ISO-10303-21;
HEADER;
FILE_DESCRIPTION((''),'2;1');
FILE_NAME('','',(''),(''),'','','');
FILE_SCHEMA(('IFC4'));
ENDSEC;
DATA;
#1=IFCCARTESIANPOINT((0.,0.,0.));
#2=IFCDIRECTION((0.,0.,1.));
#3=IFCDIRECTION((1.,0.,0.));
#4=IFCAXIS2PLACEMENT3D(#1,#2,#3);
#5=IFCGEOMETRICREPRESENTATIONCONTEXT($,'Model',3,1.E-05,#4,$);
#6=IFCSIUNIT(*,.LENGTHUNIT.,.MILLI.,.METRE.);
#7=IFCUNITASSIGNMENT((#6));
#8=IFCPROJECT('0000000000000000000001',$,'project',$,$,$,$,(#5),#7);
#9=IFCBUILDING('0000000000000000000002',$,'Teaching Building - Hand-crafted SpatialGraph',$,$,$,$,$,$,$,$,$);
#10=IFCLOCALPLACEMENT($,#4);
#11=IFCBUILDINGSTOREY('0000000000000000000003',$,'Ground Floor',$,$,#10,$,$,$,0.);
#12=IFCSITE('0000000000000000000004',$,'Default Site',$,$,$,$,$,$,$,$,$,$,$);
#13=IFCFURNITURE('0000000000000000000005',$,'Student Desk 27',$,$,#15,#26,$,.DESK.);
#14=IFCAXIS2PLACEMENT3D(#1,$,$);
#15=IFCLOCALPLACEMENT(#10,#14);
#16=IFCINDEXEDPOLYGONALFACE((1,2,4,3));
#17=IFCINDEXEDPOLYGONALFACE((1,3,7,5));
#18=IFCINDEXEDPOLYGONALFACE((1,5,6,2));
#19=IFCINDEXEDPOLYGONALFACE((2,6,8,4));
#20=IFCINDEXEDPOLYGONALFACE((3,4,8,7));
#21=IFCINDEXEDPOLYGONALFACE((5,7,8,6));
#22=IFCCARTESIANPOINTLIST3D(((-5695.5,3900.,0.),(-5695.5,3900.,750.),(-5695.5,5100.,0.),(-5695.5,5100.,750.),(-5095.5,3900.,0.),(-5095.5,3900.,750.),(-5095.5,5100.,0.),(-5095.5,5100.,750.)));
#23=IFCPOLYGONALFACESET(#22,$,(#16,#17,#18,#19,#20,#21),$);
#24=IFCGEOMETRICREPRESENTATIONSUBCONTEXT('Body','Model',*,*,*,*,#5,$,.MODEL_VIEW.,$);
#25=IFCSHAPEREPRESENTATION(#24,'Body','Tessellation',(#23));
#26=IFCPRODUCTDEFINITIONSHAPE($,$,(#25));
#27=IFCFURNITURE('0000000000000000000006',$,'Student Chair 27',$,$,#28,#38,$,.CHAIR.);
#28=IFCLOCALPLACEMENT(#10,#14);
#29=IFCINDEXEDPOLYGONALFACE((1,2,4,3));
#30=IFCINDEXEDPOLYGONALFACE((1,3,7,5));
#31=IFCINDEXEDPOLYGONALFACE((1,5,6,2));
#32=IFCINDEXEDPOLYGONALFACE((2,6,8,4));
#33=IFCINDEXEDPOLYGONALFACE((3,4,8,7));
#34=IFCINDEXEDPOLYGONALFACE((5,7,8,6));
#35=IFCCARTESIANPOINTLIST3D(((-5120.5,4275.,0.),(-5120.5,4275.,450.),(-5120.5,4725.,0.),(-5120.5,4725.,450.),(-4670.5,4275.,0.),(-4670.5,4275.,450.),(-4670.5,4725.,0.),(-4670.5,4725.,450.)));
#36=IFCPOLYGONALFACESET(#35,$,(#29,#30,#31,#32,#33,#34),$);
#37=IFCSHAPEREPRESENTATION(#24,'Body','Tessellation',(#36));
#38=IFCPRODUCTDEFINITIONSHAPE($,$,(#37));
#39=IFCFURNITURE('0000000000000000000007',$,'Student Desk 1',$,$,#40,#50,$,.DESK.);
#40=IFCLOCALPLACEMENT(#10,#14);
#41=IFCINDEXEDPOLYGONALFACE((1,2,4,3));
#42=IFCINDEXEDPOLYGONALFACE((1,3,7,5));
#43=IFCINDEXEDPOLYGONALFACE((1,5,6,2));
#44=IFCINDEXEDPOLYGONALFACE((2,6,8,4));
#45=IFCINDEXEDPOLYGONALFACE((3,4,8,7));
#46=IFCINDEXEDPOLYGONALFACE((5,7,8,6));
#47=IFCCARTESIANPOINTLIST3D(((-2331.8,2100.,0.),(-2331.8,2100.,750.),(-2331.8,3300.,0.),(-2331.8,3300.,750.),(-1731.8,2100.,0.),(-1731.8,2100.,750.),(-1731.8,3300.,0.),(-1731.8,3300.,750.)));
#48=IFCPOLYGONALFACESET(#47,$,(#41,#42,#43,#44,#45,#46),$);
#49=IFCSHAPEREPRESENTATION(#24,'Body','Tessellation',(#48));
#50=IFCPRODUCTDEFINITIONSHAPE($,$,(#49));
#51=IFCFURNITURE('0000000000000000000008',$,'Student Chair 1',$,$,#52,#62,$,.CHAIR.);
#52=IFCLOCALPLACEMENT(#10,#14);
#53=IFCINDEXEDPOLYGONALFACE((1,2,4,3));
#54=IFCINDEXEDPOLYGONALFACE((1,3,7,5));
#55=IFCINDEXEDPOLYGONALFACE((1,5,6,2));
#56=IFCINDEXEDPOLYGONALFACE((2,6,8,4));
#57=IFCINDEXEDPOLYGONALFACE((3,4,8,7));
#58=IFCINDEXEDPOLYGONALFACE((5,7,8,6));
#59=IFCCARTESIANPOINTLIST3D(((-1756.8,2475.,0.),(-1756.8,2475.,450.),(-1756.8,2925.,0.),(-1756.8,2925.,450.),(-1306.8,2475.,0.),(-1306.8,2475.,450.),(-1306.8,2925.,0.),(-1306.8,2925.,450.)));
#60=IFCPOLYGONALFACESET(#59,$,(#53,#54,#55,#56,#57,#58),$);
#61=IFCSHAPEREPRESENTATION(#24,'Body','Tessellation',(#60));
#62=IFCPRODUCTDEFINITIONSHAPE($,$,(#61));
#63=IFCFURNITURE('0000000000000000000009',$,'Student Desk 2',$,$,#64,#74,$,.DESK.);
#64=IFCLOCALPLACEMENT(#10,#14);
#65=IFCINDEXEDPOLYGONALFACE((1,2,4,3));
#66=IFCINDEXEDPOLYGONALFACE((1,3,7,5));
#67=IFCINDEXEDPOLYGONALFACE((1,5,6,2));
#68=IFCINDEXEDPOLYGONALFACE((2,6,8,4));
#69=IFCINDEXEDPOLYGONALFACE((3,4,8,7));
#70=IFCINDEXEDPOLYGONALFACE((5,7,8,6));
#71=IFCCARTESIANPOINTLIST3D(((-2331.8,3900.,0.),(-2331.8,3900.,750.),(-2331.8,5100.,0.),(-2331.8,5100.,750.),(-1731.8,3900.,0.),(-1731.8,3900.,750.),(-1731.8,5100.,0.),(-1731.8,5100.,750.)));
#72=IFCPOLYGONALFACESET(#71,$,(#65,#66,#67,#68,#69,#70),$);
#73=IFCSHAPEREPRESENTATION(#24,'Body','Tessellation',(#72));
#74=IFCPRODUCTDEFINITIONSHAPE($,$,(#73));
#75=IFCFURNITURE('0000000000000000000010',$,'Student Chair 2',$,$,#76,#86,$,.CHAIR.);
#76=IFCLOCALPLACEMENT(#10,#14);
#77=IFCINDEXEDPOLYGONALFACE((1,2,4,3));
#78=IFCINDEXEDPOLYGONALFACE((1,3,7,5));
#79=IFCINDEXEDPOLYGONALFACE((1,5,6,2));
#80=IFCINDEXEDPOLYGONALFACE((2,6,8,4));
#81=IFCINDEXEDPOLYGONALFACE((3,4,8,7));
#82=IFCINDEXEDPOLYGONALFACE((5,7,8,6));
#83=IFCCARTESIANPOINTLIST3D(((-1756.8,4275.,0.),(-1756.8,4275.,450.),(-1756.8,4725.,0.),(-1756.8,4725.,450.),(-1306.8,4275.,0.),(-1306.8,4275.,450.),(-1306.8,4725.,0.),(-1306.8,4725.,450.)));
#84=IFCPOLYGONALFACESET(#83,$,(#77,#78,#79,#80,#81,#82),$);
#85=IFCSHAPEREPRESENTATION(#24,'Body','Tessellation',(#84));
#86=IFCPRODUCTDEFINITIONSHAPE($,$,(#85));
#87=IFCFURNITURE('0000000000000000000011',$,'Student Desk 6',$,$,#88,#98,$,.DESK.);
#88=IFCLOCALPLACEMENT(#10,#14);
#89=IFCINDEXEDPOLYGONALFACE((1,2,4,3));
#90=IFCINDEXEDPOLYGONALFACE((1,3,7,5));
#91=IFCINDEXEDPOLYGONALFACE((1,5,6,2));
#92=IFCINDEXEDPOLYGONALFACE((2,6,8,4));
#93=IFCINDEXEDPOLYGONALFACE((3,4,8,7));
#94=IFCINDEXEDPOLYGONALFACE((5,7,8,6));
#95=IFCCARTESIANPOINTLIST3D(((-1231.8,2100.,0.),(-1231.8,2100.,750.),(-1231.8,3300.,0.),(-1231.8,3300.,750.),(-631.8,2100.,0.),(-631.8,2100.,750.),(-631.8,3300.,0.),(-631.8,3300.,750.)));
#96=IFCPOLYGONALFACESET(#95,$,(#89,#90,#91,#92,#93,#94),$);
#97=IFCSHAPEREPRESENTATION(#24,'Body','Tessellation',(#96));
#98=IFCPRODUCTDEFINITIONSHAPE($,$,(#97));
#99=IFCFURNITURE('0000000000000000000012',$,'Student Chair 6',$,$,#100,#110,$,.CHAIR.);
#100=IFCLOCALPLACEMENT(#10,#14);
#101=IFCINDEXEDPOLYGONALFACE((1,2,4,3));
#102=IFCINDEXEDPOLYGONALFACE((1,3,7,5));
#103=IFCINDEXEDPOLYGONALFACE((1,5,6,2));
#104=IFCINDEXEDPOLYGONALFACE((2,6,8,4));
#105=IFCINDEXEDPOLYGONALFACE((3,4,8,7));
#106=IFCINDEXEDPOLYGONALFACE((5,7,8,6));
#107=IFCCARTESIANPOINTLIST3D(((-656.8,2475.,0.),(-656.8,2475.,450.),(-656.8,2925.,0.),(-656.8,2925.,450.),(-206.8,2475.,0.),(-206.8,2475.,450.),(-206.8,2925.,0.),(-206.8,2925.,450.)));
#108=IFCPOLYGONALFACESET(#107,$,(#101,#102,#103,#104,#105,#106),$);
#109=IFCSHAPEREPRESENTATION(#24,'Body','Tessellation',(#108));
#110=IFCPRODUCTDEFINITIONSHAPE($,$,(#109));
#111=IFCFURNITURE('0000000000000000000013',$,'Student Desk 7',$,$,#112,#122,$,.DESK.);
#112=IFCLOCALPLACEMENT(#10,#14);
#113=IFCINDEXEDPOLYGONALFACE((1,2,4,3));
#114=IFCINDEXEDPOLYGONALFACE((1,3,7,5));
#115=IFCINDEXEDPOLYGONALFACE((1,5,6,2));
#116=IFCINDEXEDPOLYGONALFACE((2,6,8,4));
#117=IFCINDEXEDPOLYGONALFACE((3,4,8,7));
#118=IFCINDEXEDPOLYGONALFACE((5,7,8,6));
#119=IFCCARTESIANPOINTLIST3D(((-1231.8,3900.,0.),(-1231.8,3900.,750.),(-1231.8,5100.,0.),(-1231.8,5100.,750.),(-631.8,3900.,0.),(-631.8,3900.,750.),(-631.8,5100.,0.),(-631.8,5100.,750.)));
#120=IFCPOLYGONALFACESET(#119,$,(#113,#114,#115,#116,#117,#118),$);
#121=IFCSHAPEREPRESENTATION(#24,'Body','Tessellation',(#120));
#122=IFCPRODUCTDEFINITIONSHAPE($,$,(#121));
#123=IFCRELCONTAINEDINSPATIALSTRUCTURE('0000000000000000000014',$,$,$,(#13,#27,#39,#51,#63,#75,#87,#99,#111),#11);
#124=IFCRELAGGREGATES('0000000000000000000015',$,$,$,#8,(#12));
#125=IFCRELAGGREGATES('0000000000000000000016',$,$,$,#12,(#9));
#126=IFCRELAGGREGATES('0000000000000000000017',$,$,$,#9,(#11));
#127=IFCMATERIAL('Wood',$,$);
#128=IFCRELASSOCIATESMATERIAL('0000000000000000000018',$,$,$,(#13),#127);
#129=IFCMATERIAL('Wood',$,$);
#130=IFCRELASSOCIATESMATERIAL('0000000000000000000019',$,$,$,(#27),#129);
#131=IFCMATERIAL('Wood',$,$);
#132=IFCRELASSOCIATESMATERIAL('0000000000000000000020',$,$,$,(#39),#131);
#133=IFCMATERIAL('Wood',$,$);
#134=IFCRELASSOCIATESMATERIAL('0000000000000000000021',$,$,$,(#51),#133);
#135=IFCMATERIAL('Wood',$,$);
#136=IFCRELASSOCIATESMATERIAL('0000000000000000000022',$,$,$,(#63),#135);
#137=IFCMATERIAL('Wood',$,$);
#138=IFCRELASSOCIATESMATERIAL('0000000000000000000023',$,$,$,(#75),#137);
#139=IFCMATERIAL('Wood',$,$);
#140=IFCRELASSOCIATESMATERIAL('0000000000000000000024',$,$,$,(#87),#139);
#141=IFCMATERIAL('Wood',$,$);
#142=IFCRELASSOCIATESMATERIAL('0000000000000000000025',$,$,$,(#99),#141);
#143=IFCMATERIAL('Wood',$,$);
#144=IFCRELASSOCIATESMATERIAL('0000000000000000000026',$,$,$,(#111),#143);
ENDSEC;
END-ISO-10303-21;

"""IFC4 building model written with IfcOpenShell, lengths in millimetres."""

from ifc_helpers import new_model, si_unit, frame, origin_with_axes, origin_2d, place, context, subcontext, project, spatial, rectangle, extrude, material, element, save


model = new_model("IFC4")

# Units and contexts
model_context = context("Model", 3, precision=1e-05, world=origin_with_axes())
body_context = subcontext(model_context, "Body", "Model", "MODEL_VIEW")
ifc_project = project(units=[si_unit("LENGTHUNIT", "METRE", prefix="MILLI")], contexts=[model_context])

# Site, building, storey
site = spatial("IfcSite", under=ifc_project, Name="Default Site")
building = spatial("IfcBuilding", under=site, Name="Teaching Building - Hand-crafted SpatialGraph")
storey_placement = place(None, origin_with_axes())
storey = spatial("IfcBuildingStorey", under=building, at=storey_placement, Name="Ground Floor", Elevation=0.0)

# Furniture
ifc_material_1 = material(Name="Wood")
furniture_1_placement = place(storey_placement, frame((-5395.5, 4500.0, 0.0), z_axis=(0.0, 0.0, 1.0), x_axis=(0.0, 1.0, 0.0)))
element("IfcFurniture", 1, at=furniture_1_placement, inside=storey, material=ifc_material_1, Name="Student Desk 27", PredefinedType="DESK", context=body_context, shape_type="SweptSolid", body=[
    extrude(rectangle(XDim=1200.0, YDim=600.0, at=origin_2d()), origin_with_axes(), (0.0, 0.0, 1.0), 750.0),
])
ifc_material_2 = material(Name="Wood")
furniture_2_placement = place(storey_placement, frame((-4895.5, 4500.0, 0.0), z_axis=(0.0, 0.0, 1.0), x_axis=(1.0, 0.0, 0.0)))
element("IfcFurniture", 2, at=furniture_2_placement, inside=storey, material=ifc_material_2, Name="Student Chair 27", PredefinedType="CHAIR", context=body_context, shape_type="SweptSolid", body=[
    extrude(rectangle(XDim=450.0, YDim=450.0, at=origin_2d()), origin_with_axes(), (0.0, 0.0, 1.0), 450.0),
])
ifc_material_3 = material(Name="Wood")
furniture_3_placement = place(storey_placement, frame((-2031.8, 2700.0, 0.0), z_axis=(0.0, 0.0, 1.0), x_axis=(0.0, 1.0, 0.0)))
element("IfcFurniture", 3, at=furniture_3_placement, inside=storey, material=ifc_material_3, Name="Student Desk 1", PredefinedType="DESK", context=body_context, shape_type="SweptSolid", body=[
    extrude(rectangle(XDim=1200.0, YDim=600.0, at=origin_2d()), origin_with_axes(), (0.0, 0.0, 1.0), 750.0),
])
ifc_material_4 = material(Name="Wood")
furniture_4_placement = place(storey_placement, frame((-1531.8, 2700.0, 0.0), z_axis=(0.0, 0.0, 1.0), x_axis=(1.0, 0.0, 0.0)))
element("IfcFurniture", 4, at=furniture_4_placement, inside=storey, material=ifc_material_4, Name="Student Chair 1", PredefinedType="CHAIR", context=body_context, shape_type="SweptSolid", body=[
    extrude(rectangle(XDim=450.0, YDim=450.0, at=origin_2d()), origin_with_axes(), (0.0, 0.0, 1.0), 450.0),
])
ifc_material_5 = material(Name="Wood")
furniture_5_placement = place(storey_placement, frame((-2031.8, 4500.0, 0.0), z_axis=(0.0, 0.0, 1.0), x_axis=(0.0, 1.0, 0.0)))
element("IfcFurniture", 5, at=furniture_5_placement, inside=storey, material=ifc_material_5, Name="Student Desk 2", PredefinedType="DESK", context=body_context, shape_type="SweptSolid", body=[
    extrude(rectangle(XDim=1200.0, YDim=600.0, at=origin_2d()), origin_with_axes(), (0.0, 0.0, 1.0), 750.0),
])
ifc_material_6 = material(Name="Wood")
furniture_6_placement = place(storey_placement, frame((-1531.8, 4500.0, 0.0), z_axis=(0.0, 0.0, 1.0), x_axis=(1.0, 0.0, 0.0)))
element("IfcFurniture", 6, at=furniture_6_placement, inside=storey, material=ifc_material_6, Name="Student Chair 2", PredefinedType="CHAIR", context=body_context, shape_type="SweptSolid", body=[
    extrude(rectangle(XDim=450.0, YDim=450.0, at=origin_2d()), origin_with_axes(), (0.0, 0.0, 1.0), 450.0),
])
ifc_material_7 = material(Name="Wood")
furniture_7_placement = place(storey_placement, frame((-931.8, 2700.0, 0.0), z_axis=(0.0, 0.0, 1.0), x_axis=(0.0, 1.0, 0.0)))
element("IfcFurniture", 7, at=furniture_7_placement, inside=storey, material=ifc_material_7, Name="Student Desk 6", PredefinedType="DESK", context=body_context, shape_type="SweptSolid", body=[
    extrude(rectangle(XDim=1200.0, YDim=600.0, at=origin_2d()), origin_with_axes(), (0.0, 0.0, 1.0), 750.0),
])
ifc_material_8 = material(Name="Wood")
furniture_8_placement = place(storey_placement, frame((-431.8, 2700.0, 0.0), z_axis=(0.0, 0.0, 1.0), x_axis=(1.0, 0.0, 0.0)))
element("IfcFurniture", 8, at=furniture_8_placement, inside=storey, material=ifc_material_8, Name="Student Chair 6", PredefinedType="CHAIR", context=body_context, shape_type="SweptSolid", body=[
    extrude(rectangle(XDim=450.0, YDim=450.0, at=origin_2d()), origin_with_axes(), (0.0, 0.0, 1.0), 450.0),
])
ifc_material_9 = material(Name="Wood")
furniture_9_placement = place(storey_placement, frame((-931.8, 4500.0, 0.0), z_axis=(0.0, 0.0, 1.0), x_axis=(0.0, 1.0, 0.0)))
element("IfcFurniture", 9, at=furniture_9_placement, inside=storey, material=ifc_material_9, Name="Student Desk 7", PredefinedType="DESK", context=body_context, shape_type="SweptSolid", body=[
    extrude(rectangle(XDim=1200.0, YDim=600.0, at=origin_2d()), origin_with_axes(), (0.0, 0.0, 1.0), 750.0),
])

save(model, "model.ifc")
